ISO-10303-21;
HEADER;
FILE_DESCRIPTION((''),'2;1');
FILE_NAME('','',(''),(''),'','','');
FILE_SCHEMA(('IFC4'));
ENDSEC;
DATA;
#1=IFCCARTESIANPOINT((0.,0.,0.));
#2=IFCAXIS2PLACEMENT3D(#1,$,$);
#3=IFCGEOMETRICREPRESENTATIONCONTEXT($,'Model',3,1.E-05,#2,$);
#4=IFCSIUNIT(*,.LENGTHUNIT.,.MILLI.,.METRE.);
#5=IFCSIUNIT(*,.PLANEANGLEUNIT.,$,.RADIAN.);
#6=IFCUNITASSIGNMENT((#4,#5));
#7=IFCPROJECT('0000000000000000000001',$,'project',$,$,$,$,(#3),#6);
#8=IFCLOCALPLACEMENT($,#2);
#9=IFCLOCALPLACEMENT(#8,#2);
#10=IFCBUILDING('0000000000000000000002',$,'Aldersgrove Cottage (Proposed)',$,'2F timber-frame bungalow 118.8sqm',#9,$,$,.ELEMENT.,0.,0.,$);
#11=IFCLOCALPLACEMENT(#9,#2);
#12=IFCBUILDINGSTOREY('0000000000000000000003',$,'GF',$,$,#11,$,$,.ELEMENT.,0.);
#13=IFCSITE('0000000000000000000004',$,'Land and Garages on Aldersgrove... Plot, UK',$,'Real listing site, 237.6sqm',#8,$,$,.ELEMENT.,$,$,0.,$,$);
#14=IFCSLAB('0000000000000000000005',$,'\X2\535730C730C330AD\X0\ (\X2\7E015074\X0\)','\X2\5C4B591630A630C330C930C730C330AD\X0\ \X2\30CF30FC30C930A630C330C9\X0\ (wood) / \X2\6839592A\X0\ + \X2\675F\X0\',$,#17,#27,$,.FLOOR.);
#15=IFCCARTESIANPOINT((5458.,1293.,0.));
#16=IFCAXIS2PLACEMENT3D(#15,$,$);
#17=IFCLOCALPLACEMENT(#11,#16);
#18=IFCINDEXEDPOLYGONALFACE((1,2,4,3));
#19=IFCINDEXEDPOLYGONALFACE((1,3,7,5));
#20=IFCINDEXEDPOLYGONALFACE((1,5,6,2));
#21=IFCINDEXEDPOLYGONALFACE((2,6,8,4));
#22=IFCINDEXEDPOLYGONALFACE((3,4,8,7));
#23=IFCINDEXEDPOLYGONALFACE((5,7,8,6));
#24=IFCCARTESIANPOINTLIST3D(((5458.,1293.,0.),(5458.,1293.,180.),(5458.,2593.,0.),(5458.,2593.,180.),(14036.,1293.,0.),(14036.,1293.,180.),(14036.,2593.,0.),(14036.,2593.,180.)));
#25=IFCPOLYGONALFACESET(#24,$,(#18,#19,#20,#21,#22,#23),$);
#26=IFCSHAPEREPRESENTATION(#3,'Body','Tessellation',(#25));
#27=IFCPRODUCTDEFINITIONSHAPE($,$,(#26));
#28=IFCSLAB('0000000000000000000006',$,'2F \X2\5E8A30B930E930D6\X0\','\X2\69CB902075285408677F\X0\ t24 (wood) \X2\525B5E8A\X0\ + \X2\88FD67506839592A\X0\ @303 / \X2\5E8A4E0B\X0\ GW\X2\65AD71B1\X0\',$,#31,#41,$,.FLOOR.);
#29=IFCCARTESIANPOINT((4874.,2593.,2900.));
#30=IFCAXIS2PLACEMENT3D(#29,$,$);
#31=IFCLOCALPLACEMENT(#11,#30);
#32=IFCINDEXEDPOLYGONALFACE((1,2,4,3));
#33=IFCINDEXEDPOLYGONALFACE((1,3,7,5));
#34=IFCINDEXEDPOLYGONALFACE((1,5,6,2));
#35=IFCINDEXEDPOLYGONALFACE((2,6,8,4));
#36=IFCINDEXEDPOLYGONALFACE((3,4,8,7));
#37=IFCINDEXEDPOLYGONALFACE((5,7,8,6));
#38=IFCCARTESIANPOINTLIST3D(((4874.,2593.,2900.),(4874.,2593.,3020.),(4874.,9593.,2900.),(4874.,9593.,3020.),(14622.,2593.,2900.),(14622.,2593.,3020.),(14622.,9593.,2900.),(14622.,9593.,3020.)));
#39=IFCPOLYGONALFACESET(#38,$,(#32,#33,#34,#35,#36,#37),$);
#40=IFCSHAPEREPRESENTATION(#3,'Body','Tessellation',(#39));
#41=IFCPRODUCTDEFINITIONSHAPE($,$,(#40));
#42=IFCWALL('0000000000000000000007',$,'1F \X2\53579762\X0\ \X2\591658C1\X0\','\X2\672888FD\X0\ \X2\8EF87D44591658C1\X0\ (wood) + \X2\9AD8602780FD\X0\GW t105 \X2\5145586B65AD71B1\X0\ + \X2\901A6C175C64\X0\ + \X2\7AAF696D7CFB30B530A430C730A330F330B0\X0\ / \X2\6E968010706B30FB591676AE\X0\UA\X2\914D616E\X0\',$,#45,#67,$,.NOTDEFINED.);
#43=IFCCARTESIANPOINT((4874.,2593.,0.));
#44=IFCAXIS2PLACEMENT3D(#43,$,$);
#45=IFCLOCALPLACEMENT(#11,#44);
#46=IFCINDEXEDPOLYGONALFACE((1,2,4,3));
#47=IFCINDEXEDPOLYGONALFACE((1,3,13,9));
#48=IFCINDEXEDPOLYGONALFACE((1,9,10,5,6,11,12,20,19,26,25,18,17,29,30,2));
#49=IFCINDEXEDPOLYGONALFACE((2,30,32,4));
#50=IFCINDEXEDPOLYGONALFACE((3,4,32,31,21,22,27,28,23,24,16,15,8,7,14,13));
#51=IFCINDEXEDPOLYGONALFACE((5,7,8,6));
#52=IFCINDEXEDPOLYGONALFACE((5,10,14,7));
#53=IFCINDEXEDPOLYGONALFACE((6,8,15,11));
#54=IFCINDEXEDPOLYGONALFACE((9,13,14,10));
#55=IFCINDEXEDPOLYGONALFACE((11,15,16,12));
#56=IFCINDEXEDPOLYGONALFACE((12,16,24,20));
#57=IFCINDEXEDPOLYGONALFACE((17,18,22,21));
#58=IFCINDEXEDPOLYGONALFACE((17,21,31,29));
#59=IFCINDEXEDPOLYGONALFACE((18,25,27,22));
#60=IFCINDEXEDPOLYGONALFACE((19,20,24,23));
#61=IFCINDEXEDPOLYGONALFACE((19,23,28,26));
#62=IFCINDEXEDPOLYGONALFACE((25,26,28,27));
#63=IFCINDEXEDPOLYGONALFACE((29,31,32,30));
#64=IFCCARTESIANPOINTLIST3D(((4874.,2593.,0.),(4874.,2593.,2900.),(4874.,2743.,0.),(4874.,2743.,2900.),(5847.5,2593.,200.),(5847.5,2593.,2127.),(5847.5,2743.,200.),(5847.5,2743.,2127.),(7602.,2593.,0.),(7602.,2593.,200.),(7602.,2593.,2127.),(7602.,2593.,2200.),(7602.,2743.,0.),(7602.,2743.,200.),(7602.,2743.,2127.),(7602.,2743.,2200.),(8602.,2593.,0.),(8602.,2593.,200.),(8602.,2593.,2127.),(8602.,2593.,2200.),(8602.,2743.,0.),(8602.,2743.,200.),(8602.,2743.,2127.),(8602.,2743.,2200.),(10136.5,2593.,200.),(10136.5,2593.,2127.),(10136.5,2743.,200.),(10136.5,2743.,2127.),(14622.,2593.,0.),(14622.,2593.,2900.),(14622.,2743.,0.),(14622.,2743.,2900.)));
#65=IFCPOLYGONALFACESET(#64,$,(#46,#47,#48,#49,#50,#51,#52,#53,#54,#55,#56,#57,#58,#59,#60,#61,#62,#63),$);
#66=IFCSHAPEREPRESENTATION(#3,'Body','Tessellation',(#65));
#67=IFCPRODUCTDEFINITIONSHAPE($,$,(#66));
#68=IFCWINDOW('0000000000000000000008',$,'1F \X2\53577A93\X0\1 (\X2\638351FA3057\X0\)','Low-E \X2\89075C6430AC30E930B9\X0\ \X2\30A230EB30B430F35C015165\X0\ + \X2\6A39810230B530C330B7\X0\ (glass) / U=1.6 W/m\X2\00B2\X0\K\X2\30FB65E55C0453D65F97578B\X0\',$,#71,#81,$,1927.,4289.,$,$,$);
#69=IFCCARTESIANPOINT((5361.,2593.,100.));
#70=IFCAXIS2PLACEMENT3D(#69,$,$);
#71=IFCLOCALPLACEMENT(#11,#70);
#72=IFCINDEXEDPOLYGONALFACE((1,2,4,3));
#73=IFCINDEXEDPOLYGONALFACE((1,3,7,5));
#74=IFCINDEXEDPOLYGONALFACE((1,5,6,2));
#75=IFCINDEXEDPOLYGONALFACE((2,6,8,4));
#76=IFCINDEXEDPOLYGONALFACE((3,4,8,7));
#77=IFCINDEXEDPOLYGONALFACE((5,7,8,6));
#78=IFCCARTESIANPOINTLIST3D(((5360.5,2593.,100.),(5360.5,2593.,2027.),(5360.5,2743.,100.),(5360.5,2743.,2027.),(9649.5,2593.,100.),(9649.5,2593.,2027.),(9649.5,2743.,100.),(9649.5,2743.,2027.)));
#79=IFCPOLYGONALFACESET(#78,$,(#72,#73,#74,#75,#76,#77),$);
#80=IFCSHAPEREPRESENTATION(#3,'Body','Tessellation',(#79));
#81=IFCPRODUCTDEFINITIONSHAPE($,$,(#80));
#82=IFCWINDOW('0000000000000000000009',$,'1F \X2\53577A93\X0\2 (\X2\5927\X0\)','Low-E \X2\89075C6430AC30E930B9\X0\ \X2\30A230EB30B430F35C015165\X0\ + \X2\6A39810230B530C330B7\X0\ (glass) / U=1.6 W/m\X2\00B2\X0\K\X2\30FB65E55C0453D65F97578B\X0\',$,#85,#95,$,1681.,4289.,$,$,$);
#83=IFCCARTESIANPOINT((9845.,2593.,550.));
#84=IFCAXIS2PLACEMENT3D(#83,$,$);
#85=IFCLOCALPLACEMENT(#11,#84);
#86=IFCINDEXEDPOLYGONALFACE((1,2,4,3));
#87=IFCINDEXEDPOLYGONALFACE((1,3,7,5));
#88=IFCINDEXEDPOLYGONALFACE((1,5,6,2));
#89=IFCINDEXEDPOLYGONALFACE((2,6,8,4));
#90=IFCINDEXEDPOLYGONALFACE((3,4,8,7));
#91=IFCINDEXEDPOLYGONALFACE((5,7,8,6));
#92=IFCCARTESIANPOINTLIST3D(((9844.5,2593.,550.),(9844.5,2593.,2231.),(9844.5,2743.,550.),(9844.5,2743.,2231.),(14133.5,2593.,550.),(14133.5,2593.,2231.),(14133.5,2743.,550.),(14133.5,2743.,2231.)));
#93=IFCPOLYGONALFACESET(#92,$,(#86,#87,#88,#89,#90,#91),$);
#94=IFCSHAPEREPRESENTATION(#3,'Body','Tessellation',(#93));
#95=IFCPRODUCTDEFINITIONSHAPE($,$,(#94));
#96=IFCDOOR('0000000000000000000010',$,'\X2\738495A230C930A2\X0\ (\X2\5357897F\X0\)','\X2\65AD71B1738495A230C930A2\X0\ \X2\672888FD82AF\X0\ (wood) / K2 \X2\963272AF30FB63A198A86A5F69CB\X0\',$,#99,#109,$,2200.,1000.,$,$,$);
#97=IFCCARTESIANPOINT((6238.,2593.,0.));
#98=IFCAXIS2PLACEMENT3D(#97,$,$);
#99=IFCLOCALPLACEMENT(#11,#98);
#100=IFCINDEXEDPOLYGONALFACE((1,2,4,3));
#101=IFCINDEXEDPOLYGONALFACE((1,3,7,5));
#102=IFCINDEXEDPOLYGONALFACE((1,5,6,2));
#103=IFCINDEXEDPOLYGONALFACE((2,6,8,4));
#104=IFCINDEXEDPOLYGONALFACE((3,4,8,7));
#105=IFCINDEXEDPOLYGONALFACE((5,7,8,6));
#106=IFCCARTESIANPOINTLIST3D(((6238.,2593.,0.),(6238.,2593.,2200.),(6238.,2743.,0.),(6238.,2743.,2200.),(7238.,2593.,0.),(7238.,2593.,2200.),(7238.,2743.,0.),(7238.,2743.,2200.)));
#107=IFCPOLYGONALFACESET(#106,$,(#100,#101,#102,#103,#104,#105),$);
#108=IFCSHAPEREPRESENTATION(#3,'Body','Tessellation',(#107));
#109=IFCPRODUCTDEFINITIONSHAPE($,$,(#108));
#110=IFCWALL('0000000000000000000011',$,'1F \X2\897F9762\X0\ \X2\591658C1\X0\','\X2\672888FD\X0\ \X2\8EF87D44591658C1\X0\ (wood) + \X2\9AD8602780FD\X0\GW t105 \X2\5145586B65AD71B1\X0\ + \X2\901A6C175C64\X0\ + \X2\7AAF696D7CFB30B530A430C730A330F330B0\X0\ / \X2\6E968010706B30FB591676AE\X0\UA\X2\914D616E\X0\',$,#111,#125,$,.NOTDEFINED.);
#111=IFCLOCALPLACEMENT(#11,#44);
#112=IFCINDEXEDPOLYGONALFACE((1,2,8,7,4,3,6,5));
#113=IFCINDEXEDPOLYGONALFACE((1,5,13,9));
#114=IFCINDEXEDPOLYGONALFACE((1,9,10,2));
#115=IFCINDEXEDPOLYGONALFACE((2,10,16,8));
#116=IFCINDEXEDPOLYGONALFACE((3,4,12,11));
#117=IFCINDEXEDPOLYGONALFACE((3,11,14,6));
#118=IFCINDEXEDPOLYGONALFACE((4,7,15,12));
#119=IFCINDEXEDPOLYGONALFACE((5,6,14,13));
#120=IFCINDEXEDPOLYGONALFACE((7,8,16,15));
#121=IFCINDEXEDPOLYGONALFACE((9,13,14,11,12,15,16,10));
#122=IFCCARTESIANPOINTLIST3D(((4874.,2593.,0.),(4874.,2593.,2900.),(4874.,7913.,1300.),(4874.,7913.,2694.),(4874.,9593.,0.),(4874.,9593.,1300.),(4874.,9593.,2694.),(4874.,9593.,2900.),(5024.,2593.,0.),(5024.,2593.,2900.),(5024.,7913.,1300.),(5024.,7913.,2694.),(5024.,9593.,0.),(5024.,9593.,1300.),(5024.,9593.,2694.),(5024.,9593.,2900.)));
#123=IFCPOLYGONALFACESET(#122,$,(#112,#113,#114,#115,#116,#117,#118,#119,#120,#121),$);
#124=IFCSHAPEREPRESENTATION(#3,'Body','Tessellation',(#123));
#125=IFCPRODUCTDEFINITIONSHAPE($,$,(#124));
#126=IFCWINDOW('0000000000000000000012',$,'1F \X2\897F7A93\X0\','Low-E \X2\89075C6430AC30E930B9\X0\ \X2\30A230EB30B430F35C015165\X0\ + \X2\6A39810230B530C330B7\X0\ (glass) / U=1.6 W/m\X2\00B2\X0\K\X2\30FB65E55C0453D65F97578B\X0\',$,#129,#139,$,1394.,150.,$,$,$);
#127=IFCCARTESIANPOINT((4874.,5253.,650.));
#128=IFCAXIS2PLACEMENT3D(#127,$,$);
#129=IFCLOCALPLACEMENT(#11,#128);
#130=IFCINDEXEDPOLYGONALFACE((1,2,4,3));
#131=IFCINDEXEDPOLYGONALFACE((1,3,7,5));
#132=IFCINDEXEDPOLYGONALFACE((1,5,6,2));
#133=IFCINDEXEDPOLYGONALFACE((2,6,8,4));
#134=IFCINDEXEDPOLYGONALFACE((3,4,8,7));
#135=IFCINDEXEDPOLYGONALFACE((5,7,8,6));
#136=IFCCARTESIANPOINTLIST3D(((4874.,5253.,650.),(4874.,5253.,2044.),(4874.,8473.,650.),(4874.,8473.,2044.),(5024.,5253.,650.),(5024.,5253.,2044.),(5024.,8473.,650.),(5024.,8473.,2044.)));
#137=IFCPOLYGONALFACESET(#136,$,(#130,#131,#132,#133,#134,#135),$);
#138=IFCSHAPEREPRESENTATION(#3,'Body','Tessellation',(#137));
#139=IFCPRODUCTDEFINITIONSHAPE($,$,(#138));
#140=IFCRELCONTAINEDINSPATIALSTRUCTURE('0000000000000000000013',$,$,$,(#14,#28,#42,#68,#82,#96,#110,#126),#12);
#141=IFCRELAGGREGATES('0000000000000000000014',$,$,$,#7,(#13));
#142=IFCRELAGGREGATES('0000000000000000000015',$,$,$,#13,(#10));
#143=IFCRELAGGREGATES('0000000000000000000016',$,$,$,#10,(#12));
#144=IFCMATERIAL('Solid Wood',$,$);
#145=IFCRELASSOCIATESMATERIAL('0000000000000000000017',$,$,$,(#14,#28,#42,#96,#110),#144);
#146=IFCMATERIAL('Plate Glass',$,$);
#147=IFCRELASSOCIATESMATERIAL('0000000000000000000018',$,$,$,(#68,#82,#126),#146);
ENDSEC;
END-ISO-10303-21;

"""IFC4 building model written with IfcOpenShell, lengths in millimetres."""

from ifc_helpers import new_model, si_unit, frame, frame_2d, origin, place, context, project, spatial, rectangle, extrude, material, element, fill, save


model = new_model("IFC4")

# Units and contexts
model_context = context("Model", 3, precision=1e-05, world=origin())
ifc_project = project(units=[si_unit("LENGTHUNIT", "METRE", prefix="MILLI"), si_unit("PLANEANGLEUNIT", "RADIAN")], contexts=[model_context])

# Site, building, storey
site_placement = place(None, origin())
site = spatial("IfcSite", under=ifc_project, at=site_placement, Name="Land and Garages on Aldersgrove... Plot, UK", ObjectType="Real listing site, 237.6sqm", CompositionType="ELEMENT", RefElevation=0.0)
building_placement = place(site_placement, origin())
building = spatial("IfcBuilding", under=site, at=building_placement, Name="Aldersgrove Cottage (Proposed)", ObjectType="2F timber-frame bungalow 118.8sqm", CompositionType="ELEMENT", ElevationOfRefHeight=0.0, ElevationOfTerrain=0.0)
storey_placement = place(building_placement, origin())
storey = spatial("IfcBuildingStorey", under=building, at=storey_placement, Name="GF", CompositionType="ELEMENT", Elevation=0.0)

# Slabs
ifc_material_1 = material(Name="Solid Wood")
slab_1_placement = place(storey_placement, frame((5458.0, 1293.0, 0.0)))
element("IfcSlab", 1, at=slab_1_placement, inside=storey, material=ifc_material_1, Name="南デッキ (縁側)", Description="屋外ウッドデッキ ハードウッド (wood) / 根太 + 束", PredefinedType="FLOOR", context=model_context, shape_type="SweptSolid", body=[
    extrude(rectangle(XDim=8578.0, YDim=1300.0, at=frame_2d((4289.0, 650.0))), frame((5458.0, 1293.0, 0.0)), (0.0, 0.0, 1.0), 180.0),
])
slab_2_placement = place(storey_placement, frame((4874.0, 2593.0, 2900.0)))
element("IfcSlab", 2, at=slab_2_placement, inside=storey, material=ifc_material_1, Name="2F 床スラブ", Description="構造用合板 t24 (wood) 剛床 + 製材根太 @303 / 床下 GW断熱", PredefinedType="FLOOR", context=model_context, shape_type="SweptSolid", body=[
    extrude(rectangle(XDim=9748.0, YDim=7000.0, at=frame_2d((4874.0, 3500.0))), frame((4874.0, 2593.0, 2900.0)), (0.0, 0.0, 1.0), 120.0),
])

# Wall, openings, windows, door
wall_1_placement = place(storey_placement, frame((4874.0, 2593.0, 0.0)))
wall_1 = element("IfcWall", 3, at=wall_1_placement, inside=storey, material=ifc_material_1, Name="1F 南面 外壁", Description="木製 軸組外壁 (wood) + 高性能GW t105 充填断熱 + 通気層 + 窯業系サイディング / 準耐火・外皮UA配慮", PredefinedType="NOTDEFINED", context=model_context, shape_type="SweptSolid", body=[
    extrude(rectangle(XDim=9748.0, YDim=150.0, at=frame_2d((4874.0, 75.0))), frame((4874.0, 2593.0, 0.0)), (0.0, 0.0, 1.0), 2900.0),
])
opening_1_placement = place(storey_placement, frame((5361.0, 2593.0, 100.0)))
opening_1 = element("IfcOpeningElement", 4, at=opening_1_placement, cuts=wall_1, PredefinedType="NOTDEFINED", context=model_context, shape_type="SweptSolid", body=[
    extrude(rectangle(XDim=4289.0, YDim=150.0, at=frame_2d((2144.0, 75.0))), frame((5361.0, 2593.0, 100.0)), (0.0, 0.0, 1.0), 1927.0),
])
opening_2_placement = place(storey_placement, frame((9845.0, 2593.0, 550.0)))
opening_2 = element("IfcOpeningElement", 5, at=opening_2_placement, cuts=wall_1, PredefinedType="NOTDEFINED", context=model_context, shape_type="SweptSolid", body=[
    extrude(rectangle(XDim=4289.0, YDim=150.0, at=frame_2d((2144.0, 75.0))), frame((9845.0, 2593.0, 550.0)), (0.0, 0.0, 1.0), 1681.0),
])
opening_3_placement = place(storey_placement, frame((6238.0, 2593.0, 0.0)))
opening_3 = element("IfcOpeningElement", 6, at=opening_3_placement, cuts=wall_1, PredefinedType="NOTDEFINED", context=model_context, shape_type="SweptSolid", body=[
    extrude(rectangle(XDim=1000.0, YDim=150.0, at=frame_2d((500.0, 75.0))), frame((6238.0, 2593.0, 0.0)), (0.0, 0.0, 1.0), 2200.0),
])
ifc_material_2 = material(Name="Plate Glass")
window_1_placement = place(storey_placement, frame((5361.0, 2593.0, 100.0)))
window_1 = element("IfcWindow", 7, at=window_1_placement, inside=storey, material=ifc_material_2, Name="1F 南窓1 (掃出し)", Description="Low-E 複層ガラス アルゴン封入 + 樹脂サッシ (glass) / U=1.6 W/m²K・日射取得型", OverallHeight=1927.0, OverallWidth=4289.0, context=model_context, shape_type="SweptSolid", body=[
    extrude(rectangle(XDim=4289.0, YDim=150.0, at=frame_2d((2144.0, 75.0))), frame((5361.0, 2593.0, 100.0)), (0.0, 0.0, 1.0), 1927.0),
])
fill(opening_1, window_1)
window_2_placement = place(storey_placement, frame((9845.0, 2593.0, 550.0)))
window_2 = element("IfcWindow", 8, at=window_2_placement, inside=storey, material=ifc_material_2, Name="1F 南窓2 (大)", Description="Low-E 複層ガラス アルゴン封入 + 樹脂サッシ (glass) / U=1.6 W/m²K・日射取得型", OverallHeight=1681.0, OverallWidth=4289.0, context=model_context, shape_type="SweptSolid", body=[
    extrude(rectangle(XDim=4289.0, YDim=150.0, at=frame_2d((2144.0, 75.0))), frame((9845.0, 2593.0, 550.0)), (0.0, 0.0, 1.0), 1681.0),
])
fill(opening_2, window_2)
door_placement = place(storey_placement, frame((6238.0, 2593.0, 0.0)))
door = element("IfcDoor", 9, at=door_placement, inside=storey, material=ifc_material_1, Name="玄関ドア (南西)", Description="断熱玄関ドア 木製芯 (wood) / K2 防犯・採風機構", OverallHeight=2200.0, OverallWidth=1000.0, context=model_context, shape_type="SweptSolid", body=[
    extrude(rectangle(XDim=1000.0, YDim=150.0, at=frame_2d((500.0, 75.0))), frame((6238.0, 2593.0, 0.0)), (0.0, 0.0, 1.0), 2200.0),
])
fill(opening_3, door)

# Wall, opening, window
wall_2_placement = place(storey_placement, frame((4874.0, 2593.0, 0.0)))
wall_2 = element("IfcWall", 10, at=wall_2_placement, inside=storey, material=ifc_material_1, Name="1F 西面 外壁", Description="木製 軸組外壁 (wood) + 高性能GW t105 充填断熱 + 通気層 + 窯業系サイディング / 準耐火・外皮UA配慮", PredefinedType="NOTDEFINED", context=model_context, shape_type="SweptSolid", body=[
    extrude(rectangle(XDim=150.0, YDim=7000.0, at=frame_2d((75.0, 3500.0))), frame((4874.0, 2593.0, 0.0)), (0.0, 0.0, 1.0), 2900.0),
])
opening_4_placement = place(storey_placement, frame((4874.0, 5253.0, 650.0)))
opening_4 = element("IfcOpeningElement", 11, at=opening_4_placement, cuts=wall_2, PredefinedType="NOTDEFINED", context=model_context, shape_type="SweptSolid", body=[
    extrude(rectangle(XDim=150.0, YDim=3220.0, at=frame_2d((75.0, 1610.0))), frame((4874.0, 5253.0, 650.0)), (0.0, 0.0, 1.0), 1394.0),
])
window_3_placement = place(storey_placement, frame((4874.0, 5253.0, 650.0)))
window_3 = element("IfcWindow", 12, at=window_3_placement, inside=storey, material=ifc_material_2, Name="1F 西窓", Description="Low-E 複層ガラス アルゴン封入 + 樹脂サッシ (glass) / U=1.6 W/m²K・日射取得型", OverallHeight=1394.0, OverallWidth=150.0, context=model_context, shape_type="SweptSolid", body=[
    extrude(rectangle(XDim=150.0, YDim=3220.0, at=frame_2d((75.0, 1610.0))), frame((4874.0, 5253.0, 650.0)), (0.0, 0.0, 1.0), 1394.0),
])
fill(opening_4, window_3)

save(model, "model.ifc")
